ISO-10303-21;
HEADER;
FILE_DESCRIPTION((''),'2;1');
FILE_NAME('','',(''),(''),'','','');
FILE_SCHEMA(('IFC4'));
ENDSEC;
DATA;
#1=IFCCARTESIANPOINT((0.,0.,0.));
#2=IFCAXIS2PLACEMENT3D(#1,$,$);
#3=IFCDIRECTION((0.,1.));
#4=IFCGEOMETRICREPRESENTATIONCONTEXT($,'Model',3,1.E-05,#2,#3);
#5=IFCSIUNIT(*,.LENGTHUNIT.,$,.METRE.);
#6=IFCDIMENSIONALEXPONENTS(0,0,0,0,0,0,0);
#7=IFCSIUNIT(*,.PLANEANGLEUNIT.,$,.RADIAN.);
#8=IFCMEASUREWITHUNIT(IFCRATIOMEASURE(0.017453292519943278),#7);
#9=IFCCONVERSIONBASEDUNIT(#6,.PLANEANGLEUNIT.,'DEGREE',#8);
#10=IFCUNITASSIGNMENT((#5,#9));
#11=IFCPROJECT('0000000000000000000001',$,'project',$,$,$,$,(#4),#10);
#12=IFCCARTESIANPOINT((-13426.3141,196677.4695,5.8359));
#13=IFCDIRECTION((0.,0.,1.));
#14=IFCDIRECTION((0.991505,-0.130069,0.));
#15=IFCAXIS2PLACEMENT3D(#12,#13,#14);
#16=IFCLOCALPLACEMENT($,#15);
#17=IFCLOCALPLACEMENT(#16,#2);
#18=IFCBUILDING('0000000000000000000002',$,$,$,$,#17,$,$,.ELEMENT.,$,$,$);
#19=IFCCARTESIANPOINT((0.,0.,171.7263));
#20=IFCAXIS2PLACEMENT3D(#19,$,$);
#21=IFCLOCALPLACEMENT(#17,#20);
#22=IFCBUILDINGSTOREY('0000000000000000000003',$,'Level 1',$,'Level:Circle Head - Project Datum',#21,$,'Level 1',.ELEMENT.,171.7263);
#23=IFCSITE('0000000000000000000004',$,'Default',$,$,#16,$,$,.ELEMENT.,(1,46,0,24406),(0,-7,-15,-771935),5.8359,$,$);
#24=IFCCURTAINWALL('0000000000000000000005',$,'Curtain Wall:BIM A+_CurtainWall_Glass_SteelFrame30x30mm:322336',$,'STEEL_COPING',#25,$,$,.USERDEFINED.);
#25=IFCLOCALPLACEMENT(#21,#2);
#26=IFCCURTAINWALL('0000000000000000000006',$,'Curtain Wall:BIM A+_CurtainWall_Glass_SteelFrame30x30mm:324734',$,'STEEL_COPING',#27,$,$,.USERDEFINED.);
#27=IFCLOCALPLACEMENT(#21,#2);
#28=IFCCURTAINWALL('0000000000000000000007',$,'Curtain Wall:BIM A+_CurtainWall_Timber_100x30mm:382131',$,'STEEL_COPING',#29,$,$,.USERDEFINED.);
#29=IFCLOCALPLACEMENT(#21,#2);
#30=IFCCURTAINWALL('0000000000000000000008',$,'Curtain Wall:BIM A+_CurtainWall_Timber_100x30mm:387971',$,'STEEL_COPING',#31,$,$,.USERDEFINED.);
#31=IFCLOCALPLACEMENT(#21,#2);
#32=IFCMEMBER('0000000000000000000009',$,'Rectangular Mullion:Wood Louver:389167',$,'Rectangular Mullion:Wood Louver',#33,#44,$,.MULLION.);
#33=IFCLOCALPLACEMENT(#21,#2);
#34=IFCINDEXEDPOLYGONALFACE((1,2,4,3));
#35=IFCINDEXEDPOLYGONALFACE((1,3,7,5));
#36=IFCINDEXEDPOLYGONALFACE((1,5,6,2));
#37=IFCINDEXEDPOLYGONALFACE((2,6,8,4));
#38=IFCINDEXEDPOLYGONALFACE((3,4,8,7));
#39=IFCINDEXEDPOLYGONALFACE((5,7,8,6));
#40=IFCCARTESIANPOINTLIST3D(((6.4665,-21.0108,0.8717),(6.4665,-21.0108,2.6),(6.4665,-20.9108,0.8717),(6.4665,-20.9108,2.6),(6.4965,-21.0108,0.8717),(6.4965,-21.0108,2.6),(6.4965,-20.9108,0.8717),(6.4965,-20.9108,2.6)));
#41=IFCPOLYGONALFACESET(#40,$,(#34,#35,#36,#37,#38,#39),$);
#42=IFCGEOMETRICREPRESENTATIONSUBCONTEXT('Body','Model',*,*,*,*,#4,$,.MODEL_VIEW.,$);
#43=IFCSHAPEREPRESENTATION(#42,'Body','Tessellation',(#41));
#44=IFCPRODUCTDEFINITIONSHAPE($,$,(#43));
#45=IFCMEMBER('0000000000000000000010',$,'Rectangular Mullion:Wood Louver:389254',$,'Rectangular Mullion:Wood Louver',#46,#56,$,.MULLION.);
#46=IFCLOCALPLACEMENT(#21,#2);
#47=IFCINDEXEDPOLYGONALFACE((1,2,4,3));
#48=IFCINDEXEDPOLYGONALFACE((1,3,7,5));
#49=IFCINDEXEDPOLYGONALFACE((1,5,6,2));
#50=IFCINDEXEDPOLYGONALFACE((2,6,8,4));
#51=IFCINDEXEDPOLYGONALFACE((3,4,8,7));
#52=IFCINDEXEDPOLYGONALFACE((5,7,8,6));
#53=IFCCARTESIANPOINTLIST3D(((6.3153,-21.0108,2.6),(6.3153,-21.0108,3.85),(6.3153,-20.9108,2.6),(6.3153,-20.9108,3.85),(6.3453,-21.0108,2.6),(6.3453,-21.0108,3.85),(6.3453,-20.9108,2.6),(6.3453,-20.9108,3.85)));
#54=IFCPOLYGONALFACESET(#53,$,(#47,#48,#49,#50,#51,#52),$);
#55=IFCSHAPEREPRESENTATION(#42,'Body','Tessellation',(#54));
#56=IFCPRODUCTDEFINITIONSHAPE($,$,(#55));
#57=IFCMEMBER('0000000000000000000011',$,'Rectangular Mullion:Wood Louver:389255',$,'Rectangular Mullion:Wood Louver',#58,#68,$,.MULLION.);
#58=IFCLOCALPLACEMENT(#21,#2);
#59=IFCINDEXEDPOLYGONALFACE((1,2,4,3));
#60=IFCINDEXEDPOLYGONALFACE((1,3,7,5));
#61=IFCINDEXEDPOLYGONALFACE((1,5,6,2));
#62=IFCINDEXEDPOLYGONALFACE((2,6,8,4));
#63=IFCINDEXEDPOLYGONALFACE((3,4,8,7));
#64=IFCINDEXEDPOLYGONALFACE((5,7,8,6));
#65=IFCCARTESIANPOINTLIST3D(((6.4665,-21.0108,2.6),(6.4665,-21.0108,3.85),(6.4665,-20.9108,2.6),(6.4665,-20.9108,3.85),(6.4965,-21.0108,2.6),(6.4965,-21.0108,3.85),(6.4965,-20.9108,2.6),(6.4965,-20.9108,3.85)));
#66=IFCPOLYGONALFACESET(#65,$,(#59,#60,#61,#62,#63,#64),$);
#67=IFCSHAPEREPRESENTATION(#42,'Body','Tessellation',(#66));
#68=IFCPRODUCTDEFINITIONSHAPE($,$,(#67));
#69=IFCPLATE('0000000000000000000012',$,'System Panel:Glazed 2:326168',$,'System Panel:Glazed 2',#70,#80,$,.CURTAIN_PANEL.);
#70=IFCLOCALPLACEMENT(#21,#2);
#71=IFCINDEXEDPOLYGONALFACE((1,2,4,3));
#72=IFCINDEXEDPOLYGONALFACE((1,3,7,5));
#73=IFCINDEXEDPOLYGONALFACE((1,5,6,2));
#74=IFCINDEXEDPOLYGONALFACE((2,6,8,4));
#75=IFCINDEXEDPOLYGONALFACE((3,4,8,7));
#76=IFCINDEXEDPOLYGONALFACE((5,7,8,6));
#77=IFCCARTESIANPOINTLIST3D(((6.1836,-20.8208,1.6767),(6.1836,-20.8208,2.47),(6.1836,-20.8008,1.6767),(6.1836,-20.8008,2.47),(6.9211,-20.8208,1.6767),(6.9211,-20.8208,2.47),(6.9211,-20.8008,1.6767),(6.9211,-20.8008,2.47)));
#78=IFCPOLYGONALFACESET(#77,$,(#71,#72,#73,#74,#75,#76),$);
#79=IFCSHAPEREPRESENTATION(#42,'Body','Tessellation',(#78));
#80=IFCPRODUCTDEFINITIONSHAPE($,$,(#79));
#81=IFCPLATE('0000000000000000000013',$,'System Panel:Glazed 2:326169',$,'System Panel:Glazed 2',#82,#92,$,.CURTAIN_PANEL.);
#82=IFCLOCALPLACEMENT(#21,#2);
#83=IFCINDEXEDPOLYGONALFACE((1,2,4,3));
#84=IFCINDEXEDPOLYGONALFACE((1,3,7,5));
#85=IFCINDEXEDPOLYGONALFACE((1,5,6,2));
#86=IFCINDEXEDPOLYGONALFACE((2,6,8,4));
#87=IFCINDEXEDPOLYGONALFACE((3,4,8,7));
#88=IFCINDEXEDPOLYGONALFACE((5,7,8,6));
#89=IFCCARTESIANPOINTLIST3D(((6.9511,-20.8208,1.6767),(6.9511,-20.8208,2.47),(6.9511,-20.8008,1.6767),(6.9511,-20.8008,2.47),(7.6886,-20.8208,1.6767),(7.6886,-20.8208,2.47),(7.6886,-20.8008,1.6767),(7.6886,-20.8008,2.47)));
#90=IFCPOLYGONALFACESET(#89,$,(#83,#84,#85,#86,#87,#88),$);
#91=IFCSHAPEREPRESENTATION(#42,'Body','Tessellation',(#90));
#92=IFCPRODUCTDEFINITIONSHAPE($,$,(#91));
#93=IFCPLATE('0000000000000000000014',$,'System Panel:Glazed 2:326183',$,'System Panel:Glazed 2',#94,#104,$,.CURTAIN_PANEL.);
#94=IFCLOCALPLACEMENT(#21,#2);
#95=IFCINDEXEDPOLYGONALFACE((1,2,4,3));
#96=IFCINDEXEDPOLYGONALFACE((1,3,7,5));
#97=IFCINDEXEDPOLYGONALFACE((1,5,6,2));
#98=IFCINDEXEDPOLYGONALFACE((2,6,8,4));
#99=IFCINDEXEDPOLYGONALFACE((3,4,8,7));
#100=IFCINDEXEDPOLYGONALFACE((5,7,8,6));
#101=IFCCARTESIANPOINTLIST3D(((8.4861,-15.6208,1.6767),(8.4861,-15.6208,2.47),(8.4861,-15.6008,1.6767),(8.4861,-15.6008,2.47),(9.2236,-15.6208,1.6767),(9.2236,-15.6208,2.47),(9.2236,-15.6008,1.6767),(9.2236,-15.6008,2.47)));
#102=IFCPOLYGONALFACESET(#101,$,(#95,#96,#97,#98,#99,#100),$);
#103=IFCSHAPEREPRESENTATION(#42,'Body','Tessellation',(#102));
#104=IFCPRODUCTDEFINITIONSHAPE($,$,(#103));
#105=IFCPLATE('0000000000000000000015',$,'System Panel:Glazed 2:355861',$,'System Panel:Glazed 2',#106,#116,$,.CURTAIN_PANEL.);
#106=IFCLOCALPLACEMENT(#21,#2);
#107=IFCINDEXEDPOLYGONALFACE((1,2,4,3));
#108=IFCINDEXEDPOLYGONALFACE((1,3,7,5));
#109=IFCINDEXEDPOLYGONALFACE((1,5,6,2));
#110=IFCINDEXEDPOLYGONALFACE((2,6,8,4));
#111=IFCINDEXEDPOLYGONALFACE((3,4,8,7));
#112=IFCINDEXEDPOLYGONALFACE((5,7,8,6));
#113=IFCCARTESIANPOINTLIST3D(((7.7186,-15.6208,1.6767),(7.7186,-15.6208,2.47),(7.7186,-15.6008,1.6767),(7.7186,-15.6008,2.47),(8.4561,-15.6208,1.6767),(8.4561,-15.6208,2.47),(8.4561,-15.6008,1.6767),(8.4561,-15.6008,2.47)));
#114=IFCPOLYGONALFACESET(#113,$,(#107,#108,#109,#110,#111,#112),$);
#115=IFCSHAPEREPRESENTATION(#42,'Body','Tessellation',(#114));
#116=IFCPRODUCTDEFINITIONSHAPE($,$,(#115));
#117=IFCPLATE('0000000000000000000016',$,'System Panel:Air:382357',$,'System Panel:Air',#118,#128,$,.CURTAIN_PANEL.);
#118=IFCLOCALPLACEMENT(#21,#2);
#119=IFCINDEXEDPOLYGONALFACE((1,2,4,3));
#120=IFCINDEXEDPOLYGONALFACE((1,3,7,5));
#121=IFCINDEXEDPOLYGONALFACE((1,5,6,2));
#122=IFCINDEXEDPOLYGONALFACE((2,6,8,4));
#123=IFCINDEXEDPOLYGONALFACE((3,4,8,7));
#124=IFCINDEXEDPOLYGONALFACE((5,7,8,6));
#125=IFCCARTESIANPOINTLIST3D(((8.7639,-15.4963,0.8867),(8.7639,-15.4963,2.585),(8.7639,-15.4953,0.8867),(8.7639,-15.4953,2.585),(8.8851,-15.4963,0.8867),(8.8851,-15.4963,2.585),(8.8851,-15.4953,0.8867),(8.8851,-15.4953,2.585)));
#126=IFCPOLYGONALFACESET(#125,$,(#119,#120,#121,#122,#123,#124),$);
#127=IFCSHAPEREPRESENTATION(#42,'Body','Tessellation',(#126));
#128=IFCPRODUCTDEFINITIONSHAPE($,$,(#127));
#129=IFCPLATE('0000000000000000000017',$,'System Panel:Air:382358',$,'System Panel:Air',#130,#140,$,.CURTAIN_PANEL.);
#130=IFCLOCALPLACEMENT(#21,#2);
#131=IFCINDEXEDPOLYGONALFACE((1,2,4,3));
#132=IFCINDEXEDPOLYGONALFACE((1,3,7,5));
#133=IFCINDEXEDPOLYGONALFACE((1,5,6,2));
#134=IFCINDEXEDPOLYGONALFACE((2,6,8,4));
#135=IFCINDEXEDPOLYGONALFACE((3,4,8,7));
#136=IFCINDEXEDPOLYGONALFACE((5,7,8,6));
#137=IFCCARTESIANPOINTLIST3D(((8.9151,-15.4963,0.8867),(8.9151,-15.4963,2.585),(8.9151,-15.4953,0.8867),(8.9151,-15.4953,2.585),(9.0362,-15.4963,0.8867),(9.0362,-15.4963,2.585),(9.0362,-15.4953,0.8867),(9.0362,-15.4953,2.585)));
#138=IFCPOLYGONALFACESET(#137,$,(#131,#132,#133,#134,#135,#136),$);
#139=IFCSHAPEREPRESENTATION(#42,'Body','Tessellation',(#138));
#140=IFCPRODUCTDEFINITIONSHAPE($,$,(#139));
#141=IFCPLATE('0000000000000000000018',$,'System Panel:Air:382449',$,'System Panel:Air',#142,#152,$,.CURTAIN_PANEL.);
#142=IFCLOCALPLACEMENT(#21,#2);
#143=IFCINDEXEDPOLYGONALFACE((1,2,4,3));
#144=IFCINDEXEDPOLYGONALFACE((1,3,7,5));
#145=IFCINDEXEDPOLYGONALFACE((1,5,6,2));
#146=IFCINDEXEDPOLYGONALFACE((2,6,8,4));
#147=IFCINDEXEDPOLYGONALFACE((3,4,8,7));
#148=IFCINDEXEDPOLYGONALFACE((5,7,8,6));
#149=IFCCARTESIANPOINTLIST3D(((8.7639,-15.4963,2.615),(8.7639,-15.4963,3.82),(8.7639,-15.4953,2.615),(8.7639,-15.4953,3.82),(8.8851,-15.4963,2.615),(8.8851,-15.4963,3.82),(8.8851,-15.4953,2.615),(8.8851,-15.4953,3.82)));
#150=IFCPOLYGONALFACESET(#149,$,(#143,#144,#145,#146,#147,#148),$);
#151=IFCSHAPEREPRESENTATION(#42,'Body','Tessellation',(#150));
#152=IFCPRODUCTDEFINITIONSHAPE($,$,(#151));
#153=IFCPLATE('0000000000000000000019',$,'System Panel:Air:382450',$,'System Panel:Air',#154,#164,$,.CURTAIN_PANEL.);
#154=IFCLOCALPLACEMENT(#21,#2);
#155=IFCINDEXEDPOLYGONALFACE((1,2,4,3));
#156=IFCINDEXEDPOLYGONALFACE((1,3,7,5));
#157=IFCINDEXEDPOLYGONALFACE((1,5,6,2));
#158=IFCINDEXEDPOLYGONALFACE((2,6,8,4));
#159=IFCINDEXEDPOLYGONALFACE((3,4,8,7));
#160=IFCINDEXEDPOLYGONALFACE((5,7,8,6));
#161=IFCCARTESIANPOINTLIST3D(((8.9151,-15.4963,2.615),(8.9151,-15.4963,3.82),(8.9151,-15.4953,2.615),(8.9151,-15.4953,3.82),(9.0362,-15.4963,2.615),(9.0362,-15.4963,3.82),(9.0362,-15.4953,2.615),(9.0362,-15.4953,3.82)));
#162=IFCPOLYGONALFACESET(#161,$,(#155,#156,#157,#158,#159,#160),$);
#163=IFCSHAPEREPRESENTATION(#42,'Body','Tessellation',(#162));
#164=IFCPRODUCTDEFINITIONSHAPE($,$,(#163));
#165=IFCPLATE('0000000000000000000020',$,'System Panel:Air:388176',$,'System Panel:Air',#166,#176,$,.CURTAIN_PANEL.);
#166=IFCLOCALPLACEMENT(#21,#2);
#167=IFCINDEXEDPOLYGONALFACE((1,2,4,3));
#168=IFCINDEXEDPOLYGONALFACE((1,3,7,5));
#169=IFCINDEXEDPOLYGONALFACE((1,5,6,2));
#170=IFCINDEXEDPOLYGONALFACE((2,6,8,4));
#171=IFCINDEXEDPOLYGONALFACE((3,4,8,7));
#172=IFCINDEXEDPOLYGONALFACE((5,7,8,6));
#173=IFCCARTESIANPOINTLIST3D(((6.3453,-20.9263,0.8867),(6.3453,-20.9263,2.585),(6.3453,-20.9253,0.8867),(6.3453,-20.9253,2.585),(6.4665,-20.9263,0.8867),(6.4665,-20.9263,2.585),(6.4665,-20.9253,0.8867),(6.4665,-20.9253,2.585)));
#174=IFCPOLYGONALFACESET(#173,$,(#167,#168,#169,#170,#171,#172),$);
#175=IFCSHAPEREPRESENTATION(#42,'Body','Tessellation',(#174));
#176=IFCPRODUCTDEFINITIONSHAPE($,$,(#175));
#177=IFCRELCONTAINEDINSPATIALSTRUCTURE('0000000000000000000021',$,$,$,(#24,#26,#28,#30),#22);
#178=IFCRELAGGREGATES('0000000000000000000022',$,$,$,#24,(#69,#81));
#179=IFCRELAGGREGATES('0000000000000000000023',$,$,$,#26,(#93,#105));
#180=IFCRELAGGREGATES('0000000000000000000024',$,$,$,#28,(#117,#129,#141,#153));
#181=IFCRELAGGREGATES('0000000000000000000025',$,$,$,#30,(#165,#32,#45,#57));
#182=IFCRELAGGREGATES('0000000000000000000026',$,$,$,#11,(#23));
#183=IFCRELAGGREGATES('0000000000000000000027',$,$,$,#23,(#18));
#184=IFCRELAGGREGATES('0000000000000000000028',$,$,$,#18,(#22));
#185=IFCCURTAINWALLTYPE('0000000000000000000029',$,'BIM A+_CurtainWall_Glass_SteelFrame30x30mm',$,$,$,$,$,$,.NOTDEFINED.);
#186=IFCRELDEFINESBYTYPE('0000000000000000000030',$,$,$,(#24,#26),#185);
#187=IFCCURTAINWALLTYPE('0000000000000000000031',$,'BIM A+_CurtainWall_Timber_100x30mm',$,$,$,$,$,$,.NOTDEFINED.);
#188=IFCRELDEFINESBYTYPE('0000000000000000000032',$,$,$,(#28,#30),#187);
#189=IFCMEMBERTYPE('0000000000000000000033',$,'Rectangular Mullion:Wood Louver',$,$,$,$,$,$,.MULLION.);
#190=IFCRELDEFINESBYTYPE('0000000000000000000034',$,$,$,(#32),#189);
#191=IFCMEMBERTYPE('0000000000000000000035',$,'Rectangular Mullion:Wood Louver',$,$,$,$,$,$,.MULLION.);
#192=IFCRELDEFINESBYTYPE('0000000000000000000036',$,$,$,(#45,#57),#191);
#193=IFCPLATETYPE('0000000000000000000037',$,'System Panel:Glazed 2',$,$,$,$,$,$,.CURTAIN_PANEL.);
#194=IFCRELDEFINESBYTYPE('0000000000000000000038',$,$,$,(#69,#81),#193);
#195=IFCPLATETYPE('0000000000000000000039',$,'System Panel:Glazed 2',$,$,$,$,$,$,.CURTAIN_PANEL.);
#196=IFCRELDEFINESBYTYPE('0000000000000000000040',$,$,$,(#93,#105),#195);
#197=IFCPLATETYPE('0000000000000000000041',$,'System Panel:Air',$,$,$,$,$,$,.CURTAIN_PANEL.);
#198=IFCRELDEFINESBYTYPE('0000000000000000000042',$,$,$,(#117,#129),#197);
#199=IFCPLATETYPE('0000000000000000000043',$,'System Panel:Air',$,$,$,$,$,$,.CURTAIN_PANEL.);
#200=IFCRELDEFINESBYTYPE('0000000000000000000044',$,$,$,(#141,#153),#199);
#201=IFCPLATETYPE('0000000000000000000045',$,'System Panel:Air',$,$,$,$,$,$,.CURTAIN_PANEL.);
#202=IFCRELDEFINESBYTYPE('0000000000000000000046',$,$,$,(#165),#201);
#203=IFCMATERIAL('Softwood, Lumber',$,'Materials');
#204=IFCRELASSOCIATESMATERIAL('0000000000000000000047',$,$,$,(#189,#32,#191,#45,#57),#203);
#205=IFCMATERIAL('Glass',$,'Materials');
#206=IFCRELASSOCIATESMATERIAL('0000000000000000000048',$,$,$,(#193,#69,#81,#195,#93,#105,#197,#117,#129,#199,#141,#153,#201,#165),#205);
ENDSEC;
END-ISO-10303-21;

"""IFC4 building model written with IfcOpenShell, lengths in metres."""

from ifc_helpers import new_model, entity, si_unit, converted_unit, direction, frame, origin, place, context, subcontext, project, spatial, indexed_curve, outline, extrude, source, transform, mapped, material, type_object, type_shapes, element, aggregate, save


model = new_model("IFC4")

# Units and contexts
model_context = context("Model", 3, precision=1e-05, world=origin(), true_north=direction((0.0, 1.0)))
body_context = subcontext(model_context, "Body", "Model", "MODEL_VIEW")
ifc_project = project(units=[si_unit("LENGTHUNIT", "METRE"), converted_unit("PLANEANGLEUNIT", "DEGREE", entity("IfcRatioMeasure", 0.017453292519943278), si_unit("PLANEANGLEUNIT", "RADIAN"), dimensions=[0, 0, 0, 0, 0, 0, 0])], contexts=[model_context])

# Site, building, storey
site_placement = place(None, frame((-13426.3141, 196677.4695, 5.8359), z_axis=(0.0, 0.0, 1.0), x_axis=(0.991505, -0.130069, 0.0)))
site = spatial("IfcSite", under=ifc_project, at=site_placement, Name="Default", CompositionType="ELEMENT", RefLatitude=(1, 46, 0, 24406), RefLongitude=(0, -7, -15, -771935), RefElevation=5.8359)
building_placement = place(site_placement, origin())
building = spatial("IfcBuilding", under=site, at=building_placement, CompositionType="ELEMENT")
storey_placement = place(building_placement, frame((0.0, 0.0, 171.7263)))
storey = spatial("IfcBuildingStorey", under=building, at=storey_placement, Name="Level 1", ObjectType="Level:Circle Head - Project Datum", LongName="Level 1", CompositionType="ELEMENT", Elevation=171.7263)

# Curtain walls, members
curtain_wall_type_1 = type_object("IfcCurtainWallType", Name="BIM A+_CurtainWall_Glass_SteelFrame30x30mm", PredefinedType="NOTDEFINED")
curtain_wall_1_placement = place(storey_placement, frame((0.0, 0.0, -171.7263)))
curtain_wall_1 = element("IfcCurtainWall", 1, at=curtain_wall_1_placement, inside=storey, type_object=curtain_wall_type_1, Name="Curtain Wall:BIM A+_CurtainWall_Glass_SteelFrame30x30mm:322336", ObjectType="STEEL_COPING", PredefinedType="USERDEFINED")
curtain_wall_2_placement = place(storey_placement, frame((0.0, 0.0, -171.7263)))
curtain_wall_2 = element("IfcCurtainWall", 2, at=curtain_wall_2_placement, inside=storey, type_object=curtain_wall_type_1, Name="Curtain Wall:BIM A+_CurtainWall_Glass_SteelFrame30x30mm:324734", ObjectType="STEEL_COPING", PredefinedType="USERDEFINED")
curtain_wall_type_2 = type_object("IfcCurtainWallType", Name="BIM A+_CurtainWall_Timber_100x30mm", PredefinedType="NOTDEFINED")
curtain_wall_3_placement = place(storey_placement, frame((0.0, 0.0, -171.7263)))
curtain_wall_3 = element("IfcCurtainWall", 3, at=curtain_wall_3_placement, inside=storey, type_object=curtain_wall_type_2, Name="Curtain Wall:BIM A+_CurtainWall_Timber_100x30mm:382131", ObjectType="STEEL_COPING", PredefinedType="USERDEFINED")
ifc_material_1 = material(Name="Softwood, Lumber", Category="Materials")
curtain_wall_4_placement = place(storey_placement, frame((0.0, 0.0, -171.7263)))
curtain_wall_4 = element("IfcCurtainWall", 4, at=curtain_wall_4_placement, inside=storey, type_object=curtain_wall_type_2, Name="Curtain Wall:BIM A+_CurtainWall_Timber_100x30mm:387971", ObjectType="STEEL_COPING", PredefinedType="USERDEFINED")
member_type_1 = type_object("IfcMemberType", Name="Rectangular Mullion:Wood Louver", PredefinedType="MULLION", material=ifc_material_1)
shared_shape_1 = source(origin(), body_context, "Body", "SweptSolid", [
    extrude(outline(indexed_curve([(-0.05, -0.015), (0.05, -0.015), (0.05, 0.015), (-0.05, 0.015), (-0.05, -0.015)], self_intersect=False)), frame((0.0, 0.035, -1.7283), z_axis=(0.0, 0.0, 1.0), x_axis=(0.0, -1.0, 0.0)), (0.0, 0.0, 1.0), 1.7283),
])
type_shapes(member_type_1, [shared_shape_1])
member_1_placement = place(curtain_wall_4_placement, frame((6.4815, -20.9258, 172.598), z_axis=(0.0, 0.0, -1.0), x_axis=(1.0, 0.0, 0.0)))
member_1 = element("IfcMember", 5, at=member_1_placement, type_object=member_type_1, material=ifc_material_1, Name="Rectangular Mullion:Wood Louver:389167", ObjectType="Rectangular Mullion:Wood Louver", PredefinedType="MULLION", context=body_context, shape_type="MappedRepresentation", body=[
    mapped(shared_shape_1, transform((0.0, 0.0, 0.0), scale=1.0)),
])
member_type_2 = type_object("IfcMemberType", Name="Rectangular Mullion:Wood Louver", PredefinedType="MULLION", material=ifc_material_1)
shared_shape_2 = source(origin(), body_context, "Body", "SweptSolid", [
    extrude(outline(indexed_curve([(-0.05, -0.015), (0.05, -0.015), (0.05, 0.015), (-0.05, 0.015), (-0.05, -0.015)], self_intersect=False)), frame((0.0, 0.035, -1.25), z_axis=(0.0, 0.0, 1.0), x_axis=(0.0, -1.0, 0.0)), (0.0, 0.0, 1.0), 1.25),
])
type_shapes(member_type_2, [shared_shape_2])
member_2_placement = place(curtain_wall_4_placement, frame((6.3303, -20.9258, 174.3263), z_axis=(0.0, 0.0, -1.0), x_axis=(1.0, 0.0, 0.0)))
member_2 = element("IfcMember", 6, at=member_2_placement, type_object=member_type_2, material=ifc_material_1, Name="Rectangular Mullion:Wood Louver:389254", ObjectType="Rectangular Mullion:Wood Louver", PredefinedType="MULLION", context=body_context, shape_type="MappedRepresentation", body=[
    mapped(shared_shape_2, transform((0.0, 0.0, 0.0), scale=1.0)),
])
member_3_placement = place(curtain_wall_4_placement, frame((6.4815, -20.9258, 174.3263), z_axis=(0.0, 0.0, -1.0), x_axis=(1.0, 0.0, 0.0)))
member_3 = element("IfcMember", 7, at=member_3_placement, type_object=member_type_2, material=ifc_material_1, Name="Rectangular Mullion:Wood Louver:389255", ObjectType="Rectangular Mullion:Wood Louver", PredefinedType="MULLION", context=body_context, shape_type="MappedRepresentation", body=[
    mapped(shared_shape_2, transform((0.0, 0.0, 0.0), scale=1.0)),
])

# Plates
ifc_material_2 = material(Name="Glass", Category="Materials")
plate_type_1 = type_object("IfcPlateType", Name="System Panel:Glazed 2", PredefinedType="CURTAIN_PANEL", material=ifc_material_2)
shared_shape_3 = source(origin(), body_context, "Body", "SweptSolid", [
    extrude(outline(indexed_curve([(-0.01, -0.3688), (0.01, -0.3688), (0.01, 0.3688), (-0.01, 0.3688), (-0.01, -0.3688)], self_intersect=False)), frame((0.0, 0.0, 0.0), z_axis=(0.0, 0.0, 1.0), x_axis=(0.0, 1.0, 0.0)), (0.0, 0.0, 1.0), 0.7933),
])
type_shapes(plate_type_1, [shared_shape_3])
plate_1_placement = place(curtain_wall_1_placement, frame((6.5523, -20.8108, 173.4029)))
plate_1 = element("IfcPlate", 8, at=plate_1_placement, type_object=plate_type_1, material=ifc_material_2, Name="System Panel:Glazed 2:326168", ObjectType="System Panel:Glazed 2", PredefinedType="CURTAIN_PANEL", context=body_context, shape_type="MappedRepresentation", body=[
    mapped(shared_shape_3, transform((0.0, 0.0, 0.0), scale=1.0)),
])
plate_2_placement = place(curtain_wall_1_placement, frame((7.3198, -20.8108, 173.4029)))
plate_2 = element("IfcPlate", 9, at=plate_2_placement, type_object=plate_type_1, material=ifc_material_2, Name="System Panel:Glazed 2:326169", ObjectType="System Panel:Glazed 2", PredefinedType="CURTAIN_PANEL", context=body_context, shape_type="MappedRepresentation", body=[
    mapped(shared_shape_3, transform((0.0, 0.0, 0.0), scale=1.0)),
])
aggregate(curtain_wall_1, [plate_1, plate_2])
plate_type_2 = type_object("IfcPlateType", Name="System Panel:Glazed 2", PredefinedType="CURTAIN_PANEL", material=ifc_material_2)
shared_shape_4 = source(origin(), body_context, "Body", "SweptSolid", [
    extrude(outline(indexed_curve([(-0.01, -0.3688), (0.01, -0.3688), (0.01, 0.3688), (-0.01, 0.3688), (-0.01, -0.3688)], self_intersect=False)), frame((0.0, 0.0, 0.0), z_axis=(0.0, 0.0, 1.0), x_axis=(0.0, 1.0, 0.0)), (0.0, 0.0, 1.0), 0.7933),
])
type_shapes(plate_type_2, [shared_shape_4])
plate_3_placement = place(curtain_wall_2_placement, frame((8.8548, -15.6108, 173.4029), z_axis=(0.0, 0.0, 1.0), x_axis=(-1.0, 0.0, 0.0)))
plate_3 = element("IfcPlate", 10, at=plate_3_placement, type_object=plate_type_2, material=ifc_material_2, Name="System Panel:Glazed 2:326183", ObjectType="System Panel:Glazed 2", PredefinedType="CURTAIN_PANEL", context=body_context, shape_type="MappedRepresentation", body=[
    mapped(shared_shape_4, transform((0.0, 0.0, 0.0), scale=1.0)),
])
plate_4_placement = place(curtain_wall_2_placement, frame((8.0873, -15.6108, 173.4029), z_axis=(0.0, 0.0, 1.0), x_axis=(-1.0, 0.0, 0.0)))
plate_4 = element("IfcPlate", 11, at=plate_4_placement, type_object=plate_type_2, material=ifc_material_2, Name="System Panel:Glazed 2:355861", ObjectType="System Panel:Glazed 2", PredefinedType="CURTAIN_PANEL", context=body_context, shape_type="MappedRepresentation", body=[
    mapped(shared_shape_4, transform((0.0, 0.0, 0.0), scale=1.0)),
])
aggregate(curtain_wall_2, [plate_3, plate_4])
plate_type_3 = type_object("IfcPlateType", Name="System Panel:Air", PredefinedType="CURTAIN_PANEL", material=ifc_material_2)
shared_shape_5 = source(origin(), body_context, "Body", "SweptSolid", [
    extrude(outline(indexed_curve([(-0.0005, -0.0606), (0.0005, -0.0606), (0.0005, 0.0606), (-0.0005, 0.0606), (-0.0005, -0.0606)], self_intersect=False)), frame((0.0, 0.0, 0.0), z_axis=(0.0, 0.0, 1.0), x_axis=(0.0, 1.0, 0.0)), (0.0, 0.0, 1.0), 1.6983),
])
type_shapes(plate_type_3, [shared_shape_5])
plate_5_placement = place(curtain_wall_3_placement, frame((8.8245, -15.4958, 172.613)))
plate_5 = element("IfcPlate", 12, at=plate_5_placement, type_object=plate_type_3, material=ifc_material_2, Name="System Panel:Air:382357", ObjectType="System Panel:Air", PredefinedType="CURTAIN_PANEL", context=body_context, shape_type="MappedRepresentation", body=[
    mapped(shared_shape_5, transform((0.0, 0.0, 0.0), scale=1.0)),
])
plate_6_placement = place(curtain_wall_3_placement, frame((8.9757, -15.4958, 172.613)))
plate_6 = element("IfcPlate", 13, at=plate_6_placement, type_object=plate_type_3, material=ifc_material_2, Name="System Panel:Air:382358", ObjectType="System Panel:Air", PredefinedType="CURTAIN_PANEL", context=body_context, shape_type="MappedRepresentation", body=[
    mapped(shared_shape_5, transform((0.0, 0.0, 0.0), scale=1.0)),
])
plate_type_4 = type_object("IfcPlateType", Name="System Panel:Air", PredefinedType="CURTAIN_PANEL", material=ifc_material_2)
shared_shape_6 = source(origin(), body_context, "Body", "SweptSolid", [
    extrude(outline(indexed_curve([(-0.0005, -0.0606), (0.0005, -0.0606), (0.0005, 0.0606), (-0.0005, 0.0606), (-0.0005, -0.0606)], self_intersect=False)), frame((0.0, 0.0, 0.0), z_axis=(0.0, 0.0, 1.0), x_axis=(0.0, 1.0, 0.0)), (0.0, 0.0, 1.0), 1.205),
])
type_shapes(plate_type_4, [shared_shape_6])
plate_7_placement = place(curtain_wall_3_placement, frame((8.8245, -15.4958, 174.3413)))
plate_7 = element("IfcPlate", 14, at=plate_7_placement, type_object=plate_type_4, material=ifc_material_2, Name="System Panel:Air:382449", ObjectType="System Panel:Air", PredefinedType="CURTAIN_PANEL", context=body_context, shape_type="MappedRepresentation", body=[
    mapped(shared_shape_6, transform((0.0, 0.0, 0.0), scale=1.0)),
])
plate_8_placement = place(curtain_wall_3_placement, frame((8.9757, -15.4958, 174.3413)))
plate_8 = element("IfcPlate", 15, at=plate_8_placement, type_object=plate_type_4, material=ifc_material_2, Name="System Panel:Air:382450", ObjectType="System Panel:Air", PredefinedType="CURTAIN_PANEL", context=body_context, shape_type="MappedRepresentation", body=[
    mapped(shared_shape_6, transform((0.0, 0.0, 0.0), scale=1.0)),
])
aggregate(curtain_wall_3, [plate_5, plate_6, plate_7, plate_8])
plate_type_5 = type_object("IfcPlateType", Name="System Panel:Air", PredefinedType="CURTAIN_PANEL", material=ifc_material_2)
shared_shape_7 = source(origin(), body_context, "Body", "SweptSolid", [
    extrude(outline(indexed_curve([(-0.0005, -0.0606), (0.0005, -0.0606), (0.0005, 0.0606), (-0.0005, 0.0606), (-0.0005, -0.0606)], self_intersect=False)), frame((0.0, 0.0, 0.0), z_axis=(0.0, 0.0, 1.0), x_axis=(0.0, 1.0, 0.0)), (0.0, 0.0, 1.0), 1.6983),
])
type_shapes(plate_type_5, [shared_shape_7])
plate_9_placement = place(curtain_wall_4_placement, frame((6.4059, -20.9258, 172.613)))
plate_9 = element("IfcPlate", 16, at=plate_9_placement, type_object=plate_type_5, material=ifc_material_2, Name="System Panel:Air:388176", ObjectType="System Panel:Air", PredefinedType="CURTAIN_PANEL", context=body_context, shape_type="MappedRepresentation", body=[
    mapped(shared_shape_7, transform((0.0, 0.0, 0.0), scale=1.0)),
])
aggregate(curtain_wall_4, [plate_9, member_1, member_2, member_3])

save(model, "model.ifc")
